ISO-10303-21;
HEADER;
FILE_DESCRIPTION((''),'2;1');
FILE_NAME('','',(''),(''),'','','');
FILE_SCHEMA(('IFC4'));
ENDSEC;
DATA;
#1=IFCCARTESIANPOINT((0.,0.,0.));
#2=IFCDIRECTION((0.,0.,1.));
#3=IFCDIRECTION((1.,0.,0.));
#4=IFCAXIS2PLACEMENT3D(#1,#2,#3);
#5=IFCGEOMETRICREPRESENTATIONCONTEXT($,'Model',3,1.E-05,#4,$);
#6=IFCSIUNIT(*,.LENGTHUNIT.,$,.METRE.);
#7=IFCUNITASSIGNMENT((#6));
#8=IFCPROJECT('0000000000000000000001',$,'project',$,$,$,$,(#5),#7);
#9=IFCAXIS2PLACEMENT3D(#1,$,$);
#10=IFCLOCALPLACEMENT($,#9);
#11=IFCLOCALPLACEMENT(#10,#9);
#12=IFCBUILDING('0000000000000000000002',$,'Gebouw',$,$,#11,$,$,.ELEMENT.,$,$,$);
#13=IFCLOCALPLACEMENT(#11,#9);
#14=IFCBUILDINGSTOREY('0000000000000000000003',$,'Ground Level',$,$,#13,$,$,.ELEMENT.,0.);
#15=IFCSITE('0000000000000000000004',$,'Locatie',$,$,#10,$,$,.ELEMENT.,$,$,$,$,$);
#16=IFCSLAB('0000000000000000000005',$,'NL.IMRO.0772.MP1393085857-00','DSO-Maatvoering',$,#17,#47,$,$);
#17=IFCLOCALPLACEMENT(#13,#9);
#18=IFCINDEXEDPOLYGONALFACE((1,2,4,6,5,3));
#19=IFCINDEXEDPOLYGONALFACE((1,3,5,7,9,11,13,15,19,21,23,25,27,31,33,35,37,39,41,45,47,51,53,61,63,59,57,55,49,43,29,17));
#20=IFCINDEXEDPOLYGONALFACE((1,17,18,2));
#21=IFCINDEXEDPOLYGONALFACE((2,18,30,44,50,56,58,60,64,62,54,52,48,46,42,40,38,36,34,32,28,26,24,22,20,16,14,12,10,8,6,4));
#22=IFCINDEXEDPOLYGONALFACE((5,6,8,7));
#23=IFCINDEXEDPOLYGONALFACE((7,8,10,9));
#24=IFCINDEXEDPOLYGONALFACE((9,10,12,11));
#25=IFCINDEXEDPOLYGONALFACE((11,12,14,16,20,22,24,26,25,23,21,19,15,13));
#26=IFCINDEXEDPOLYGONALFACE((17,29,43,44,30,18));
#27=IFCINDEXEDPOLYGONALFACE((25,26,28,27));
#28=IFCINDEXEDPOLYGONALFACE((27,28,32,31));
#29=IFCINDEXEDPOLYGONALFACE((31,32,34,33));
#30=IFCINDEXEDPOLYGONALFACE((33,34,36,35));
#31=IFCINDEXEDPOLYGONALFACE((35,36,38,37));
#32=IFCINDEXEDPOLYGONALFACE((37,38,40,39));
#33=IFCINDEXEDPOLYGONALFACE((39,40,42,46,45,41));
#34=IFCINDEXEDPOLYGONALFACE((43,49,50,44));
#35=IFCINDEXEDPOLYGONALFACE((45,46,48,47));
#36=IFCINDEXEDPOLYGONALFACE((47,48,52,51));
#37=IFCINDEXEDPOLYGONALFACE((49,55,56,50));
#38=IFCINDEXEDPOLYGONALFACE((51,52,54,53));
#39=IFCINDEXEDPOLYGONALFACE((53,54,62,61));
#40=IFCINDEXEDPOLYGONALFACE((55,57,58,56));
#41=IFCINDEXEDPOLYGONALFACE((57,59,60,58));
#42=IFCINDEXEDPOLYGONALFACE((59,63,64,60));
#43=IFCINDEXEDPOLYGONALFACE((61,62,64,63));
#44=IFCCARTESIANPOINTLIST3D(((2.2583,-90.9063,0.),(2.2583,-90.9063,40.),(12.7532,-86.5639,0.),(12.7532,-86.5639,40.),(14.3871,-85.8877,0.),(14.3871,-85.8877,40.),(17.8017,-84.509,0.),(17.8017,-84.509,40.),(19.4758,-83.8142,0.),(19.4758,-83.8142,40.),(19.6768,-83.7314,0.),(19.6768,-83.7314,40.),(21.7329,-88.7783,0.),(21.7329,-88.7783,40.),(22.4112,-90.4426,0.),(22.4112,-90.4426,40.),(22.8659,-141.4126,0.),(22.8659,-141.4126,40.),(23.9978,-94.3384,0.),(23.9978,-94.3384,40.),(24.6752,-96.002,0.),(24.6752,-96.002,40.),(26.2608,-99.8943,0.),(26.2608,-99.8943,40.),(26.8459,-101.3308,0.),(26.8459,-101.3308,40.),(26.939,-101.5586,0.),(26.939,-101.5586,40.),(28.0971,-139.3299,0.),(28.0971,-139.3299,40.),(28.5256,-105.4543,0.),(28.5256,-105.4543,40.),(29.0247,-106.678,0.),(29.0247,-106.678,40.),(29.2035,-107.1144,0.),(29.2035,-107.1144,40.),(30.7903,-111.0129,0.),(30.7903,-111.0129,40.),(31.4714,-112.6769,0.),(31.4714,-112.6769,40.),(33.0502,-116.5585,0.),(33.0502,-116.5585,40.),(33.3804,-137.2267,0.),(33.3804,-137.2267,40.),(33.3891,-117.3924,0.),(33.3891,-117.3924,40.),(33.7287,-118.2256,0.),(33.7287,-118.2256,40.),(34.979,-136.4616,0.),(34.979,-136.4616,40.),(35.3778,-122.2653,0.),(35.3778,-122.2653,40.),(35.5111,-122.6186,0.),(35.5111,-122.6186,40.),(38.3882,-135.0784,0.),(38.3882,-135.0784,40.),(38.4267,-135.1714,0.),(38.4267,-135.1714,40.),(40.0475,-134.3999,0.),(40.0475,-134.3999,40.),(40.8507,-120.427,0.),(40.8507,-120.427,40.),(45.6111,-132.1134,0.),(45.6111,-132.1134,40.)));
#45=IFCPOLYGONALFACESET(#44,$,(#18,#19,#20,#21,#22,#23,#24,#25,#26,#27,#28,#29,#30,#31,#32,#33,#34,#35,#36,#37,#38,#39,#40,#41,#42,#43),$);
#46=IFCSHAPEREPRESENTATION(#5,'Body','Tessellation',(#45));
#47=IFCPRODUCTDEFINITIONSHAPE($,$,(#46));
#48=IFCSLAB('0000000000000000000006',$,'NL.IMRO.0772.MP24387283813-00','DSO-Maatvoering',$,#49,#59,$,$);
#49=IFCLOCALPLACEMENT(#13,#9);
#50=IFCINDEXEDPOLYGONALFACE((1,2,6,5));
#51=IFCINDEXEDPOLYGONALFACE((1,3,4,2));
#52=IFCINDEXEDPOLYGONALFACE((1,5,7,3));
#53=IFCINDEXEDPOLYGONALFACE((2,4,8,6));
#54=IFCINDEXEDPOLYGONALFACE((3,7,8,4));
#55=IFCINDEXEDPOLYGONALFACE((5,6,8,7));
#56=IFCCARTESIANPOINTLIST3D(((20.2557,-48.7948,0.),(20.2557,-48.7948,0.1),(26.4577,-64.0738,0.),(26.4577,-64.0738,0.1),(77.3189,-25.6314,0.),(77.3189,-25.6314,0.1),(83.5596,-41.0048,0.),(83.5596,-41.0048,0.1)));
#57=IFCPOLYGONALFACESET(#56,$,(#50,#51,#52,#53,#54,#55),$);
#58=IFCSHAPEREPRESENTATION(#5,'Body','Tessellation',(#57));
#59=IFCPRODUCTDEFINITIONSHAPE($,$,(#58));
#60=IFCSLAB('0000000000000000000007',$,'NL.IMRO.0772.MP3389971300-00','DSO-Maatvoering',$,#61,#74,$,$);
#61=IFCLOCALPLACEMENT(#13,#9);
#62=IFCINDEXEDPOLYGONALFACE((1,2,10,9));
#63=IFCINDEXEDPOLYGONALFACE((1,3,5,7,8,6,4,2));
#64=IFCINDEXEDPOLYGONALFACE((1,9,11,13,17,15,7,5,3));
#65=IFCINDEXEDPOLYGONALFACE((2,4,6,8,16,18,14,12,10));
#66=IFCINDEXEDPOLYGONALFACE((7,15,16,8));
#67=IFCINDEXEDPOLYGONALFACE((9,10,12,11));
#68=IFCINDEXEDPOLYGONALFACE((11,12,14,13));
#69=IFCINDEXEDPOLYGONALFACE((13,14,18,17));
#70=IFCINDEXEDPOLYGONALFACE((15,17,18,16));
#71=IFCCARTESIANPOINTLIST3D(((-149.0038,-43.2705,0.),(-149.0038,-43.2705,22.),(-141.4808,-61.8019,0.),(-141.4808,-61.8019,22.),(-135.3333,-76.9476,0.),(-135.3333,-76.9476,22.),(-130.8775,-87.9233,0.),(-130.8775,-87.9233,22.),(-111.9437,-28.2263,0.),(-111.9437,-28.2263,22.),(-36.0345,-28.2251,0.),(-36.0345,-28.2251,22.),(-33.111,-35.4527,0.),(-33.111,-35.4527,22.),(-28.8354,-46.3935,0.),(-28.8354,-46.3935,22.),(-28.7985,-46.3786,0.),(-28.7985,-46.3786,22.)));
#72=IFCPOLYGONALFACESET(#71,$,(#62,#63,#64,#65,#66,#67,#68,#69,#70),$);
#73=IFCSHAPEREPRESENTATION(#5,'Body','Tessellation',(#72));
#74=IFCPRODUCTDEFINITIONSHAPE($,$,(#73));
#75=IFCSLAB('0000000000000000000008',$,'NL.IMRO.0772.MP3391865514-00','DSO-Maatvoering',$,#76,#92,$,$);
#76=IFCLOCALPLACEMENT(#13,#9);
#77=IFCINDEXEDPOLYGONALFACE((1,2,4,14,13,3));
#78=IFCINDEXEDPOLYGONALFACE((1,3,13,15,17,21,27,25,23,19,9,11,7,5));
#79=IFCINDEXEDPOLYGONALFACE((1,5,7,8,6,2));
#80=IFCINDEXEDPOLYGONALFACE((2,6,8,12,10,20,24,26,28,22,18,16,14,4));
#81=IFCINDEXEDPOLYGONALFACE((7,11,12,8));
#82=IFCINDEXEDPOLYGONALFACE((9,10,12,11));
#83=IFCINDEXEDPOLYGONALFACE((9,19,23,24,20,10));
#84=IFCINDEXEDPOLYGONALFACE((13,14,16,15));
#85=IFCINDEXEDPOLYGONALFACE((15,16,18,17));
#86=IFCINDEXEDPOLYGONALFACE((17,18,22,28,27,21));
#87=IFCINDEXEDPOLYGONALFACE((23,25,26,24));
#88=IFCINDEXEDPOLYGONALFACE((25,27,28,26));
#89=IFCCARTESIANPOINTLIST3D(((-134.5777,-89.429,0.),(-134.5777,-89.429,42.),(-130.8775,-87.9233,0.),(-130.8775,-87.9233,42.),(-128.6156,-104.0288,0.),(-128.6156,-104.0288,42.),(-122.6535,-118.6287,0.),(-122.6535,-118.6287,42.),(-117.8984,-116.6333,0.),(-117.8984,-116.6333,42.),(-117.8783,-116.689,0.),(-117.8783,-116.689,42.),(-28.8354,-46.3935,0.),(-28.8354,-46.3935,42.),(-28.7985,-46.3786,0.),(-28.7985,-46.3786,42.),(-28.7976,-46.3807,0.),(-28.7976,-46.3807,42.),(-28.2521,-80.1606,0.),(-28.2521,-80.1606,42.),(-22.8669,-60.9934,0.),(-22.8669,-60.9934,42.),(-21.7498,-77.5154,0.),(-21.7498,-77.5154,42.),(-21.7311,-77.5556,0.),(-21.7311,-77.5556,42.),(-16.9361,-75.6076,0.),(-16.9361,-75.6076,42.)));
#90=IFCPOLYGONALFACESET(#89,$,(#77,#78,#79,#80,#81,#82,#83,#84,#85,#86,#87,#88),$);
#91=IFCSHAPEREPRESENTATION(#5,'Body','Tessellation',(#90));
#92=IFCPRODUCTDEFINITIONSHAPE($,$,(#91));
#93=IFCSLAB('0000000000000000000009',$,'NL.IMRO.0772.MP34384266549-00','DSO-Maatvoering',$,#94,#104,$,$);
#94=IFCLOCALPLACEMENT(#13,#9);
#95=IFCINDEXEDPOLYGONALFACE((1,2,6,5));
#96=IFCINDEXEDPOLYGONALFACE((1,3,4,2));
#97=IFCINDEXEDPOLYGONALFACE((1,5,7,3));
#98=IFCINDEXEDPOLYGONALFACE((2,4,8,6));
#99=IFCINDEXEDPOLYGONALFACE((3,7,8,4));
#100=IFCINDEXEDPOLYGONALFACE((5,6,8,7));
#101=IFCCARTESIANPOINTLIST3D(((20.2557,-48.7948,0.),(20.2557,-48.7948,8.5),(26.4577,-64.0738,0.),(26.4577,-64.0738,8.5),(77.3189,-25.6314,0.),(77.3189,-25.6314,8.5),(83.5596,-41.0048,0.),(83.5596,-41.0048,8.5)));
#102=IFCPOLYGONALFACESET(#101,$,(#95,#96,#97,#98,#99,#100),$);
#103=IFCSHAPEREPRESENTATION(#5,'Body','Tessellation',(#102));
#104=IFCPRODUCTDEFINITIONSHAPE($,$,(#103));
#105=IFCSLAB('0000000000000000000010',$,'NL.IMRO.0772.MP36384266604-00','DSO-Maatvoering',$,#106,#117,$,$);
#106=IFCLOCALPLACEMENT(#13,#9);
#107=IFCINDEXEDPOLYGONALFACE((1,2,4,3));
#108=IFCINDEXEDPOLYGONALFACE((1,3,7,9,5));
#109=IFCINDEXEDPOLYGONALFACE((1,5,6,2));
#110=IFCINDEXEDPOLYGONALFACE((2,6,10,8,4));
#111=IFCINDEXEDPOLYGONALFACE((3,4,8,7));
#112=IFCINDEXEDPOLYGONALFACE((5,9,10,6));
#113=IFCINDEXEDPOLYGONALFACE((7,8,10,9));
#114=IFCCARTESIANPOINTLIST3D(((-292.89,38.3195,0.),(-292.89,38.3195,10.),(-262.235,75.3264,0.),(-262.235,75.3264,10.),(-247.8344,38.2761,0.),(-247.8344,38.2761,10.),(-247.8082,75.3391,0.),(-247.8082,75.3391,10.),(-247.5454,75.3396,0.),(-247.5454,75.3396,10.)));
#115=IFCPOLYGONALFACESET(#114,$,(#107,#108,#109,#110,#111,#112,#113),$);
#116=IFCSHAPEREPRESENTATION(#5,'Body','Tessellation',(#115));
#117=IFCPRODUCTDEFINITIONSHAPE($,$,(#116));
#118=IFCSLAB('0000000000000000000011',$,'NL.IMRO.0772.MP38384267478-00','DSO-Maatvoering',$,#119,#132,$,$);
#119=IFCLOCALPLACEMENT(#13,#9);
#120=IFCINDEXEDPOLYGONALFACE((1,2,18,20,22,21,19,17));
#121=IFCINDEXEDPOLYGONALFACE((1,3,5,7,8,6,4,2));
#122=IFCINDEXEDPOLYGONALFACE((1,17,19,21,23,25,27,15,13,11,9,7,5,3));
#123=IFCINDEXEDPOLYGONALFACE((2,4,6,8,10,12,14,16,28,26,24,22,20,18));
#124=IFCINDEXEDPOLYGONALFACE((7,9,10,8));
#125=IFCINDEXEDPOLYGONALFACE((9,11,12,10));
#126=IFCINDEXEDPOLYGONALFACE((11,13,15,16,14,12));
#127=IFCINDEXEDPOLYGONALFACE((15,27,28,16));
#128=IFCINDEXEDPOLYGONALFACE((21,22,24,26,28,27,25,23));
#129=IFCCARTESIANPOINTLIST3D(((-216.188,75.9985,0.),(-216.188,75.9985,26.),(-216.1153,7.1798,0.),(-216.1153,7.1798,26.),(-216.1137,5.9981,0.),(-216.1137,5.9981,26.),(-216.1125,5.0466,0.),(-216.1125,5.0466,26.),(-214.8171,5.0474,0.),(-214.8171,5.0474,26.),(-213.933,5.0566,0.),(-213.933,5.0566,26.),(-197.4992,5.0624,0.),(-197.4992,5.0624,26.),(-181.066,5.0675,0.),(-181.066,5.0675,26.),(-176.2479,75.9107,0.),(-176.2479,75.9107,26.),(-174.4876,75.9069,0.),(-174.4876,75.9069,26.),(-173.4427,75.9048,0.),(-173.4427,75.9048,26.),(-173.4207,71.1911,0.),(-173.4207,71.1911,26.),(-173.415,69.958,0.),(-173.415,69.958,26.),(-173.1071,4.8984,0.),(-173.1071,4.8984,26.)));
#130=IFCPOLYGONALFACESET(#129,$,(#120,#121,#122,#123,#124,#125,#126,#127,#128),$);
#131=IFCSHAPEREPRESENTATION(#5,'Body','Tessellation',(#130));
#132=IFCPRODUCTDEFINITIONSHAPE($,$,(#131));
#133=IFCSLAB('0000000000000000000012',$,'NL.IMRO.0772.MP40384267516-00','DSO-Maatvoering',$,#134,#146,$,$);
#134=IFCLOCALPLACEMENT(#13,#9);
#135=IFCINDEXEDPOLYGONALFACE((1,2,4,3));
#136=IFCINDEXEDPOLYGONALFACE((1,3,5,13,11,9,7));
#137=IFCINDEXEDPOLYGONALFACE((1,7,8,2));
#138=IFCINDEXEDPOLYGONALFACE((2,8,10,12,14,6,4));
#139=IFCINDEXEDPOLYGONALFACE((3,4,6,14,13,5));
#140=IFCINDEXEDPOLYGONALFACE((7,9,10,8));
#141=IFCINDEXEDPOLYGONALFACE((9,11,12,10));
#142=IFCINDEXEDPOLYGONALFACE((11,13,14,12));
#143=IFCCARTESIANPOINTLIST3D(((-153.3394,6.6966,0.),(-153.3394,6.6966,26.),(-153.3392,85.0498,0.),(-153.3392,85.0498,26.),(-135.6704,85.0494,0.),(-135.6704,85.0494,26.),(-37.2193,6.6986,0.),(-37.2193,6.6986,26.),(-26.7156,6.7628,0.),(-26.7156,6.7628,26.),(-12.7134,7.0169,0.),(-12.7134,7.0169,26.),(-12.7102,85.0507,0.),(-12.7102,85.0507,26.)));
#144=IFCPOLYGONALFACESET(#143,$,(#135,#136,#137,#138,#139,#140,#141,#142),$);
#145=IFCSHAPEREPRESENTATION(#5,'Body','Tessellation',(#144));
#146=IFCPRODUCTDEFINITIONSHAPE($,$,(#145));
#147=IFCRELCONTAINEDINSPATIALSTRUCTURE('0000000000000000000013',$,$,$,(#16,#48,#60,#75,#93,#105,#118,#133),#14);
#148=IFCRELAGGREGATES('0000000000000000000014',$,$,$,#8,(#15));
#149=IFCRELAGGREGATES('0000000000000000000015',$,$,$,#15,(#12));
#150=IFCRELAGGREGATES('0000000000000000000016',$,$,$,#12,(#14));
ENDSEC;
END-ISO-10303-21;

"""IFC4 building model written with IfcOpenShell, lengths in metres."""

from ifc_helpers import new_model, si_unit, origin, origin_with_axes, place, context, project, spatial, polyline, outline, extrude, element, save


model = new_model("IFC4")

# Units and contexts
model_context = context("Model", 3, precision=1e-05, world=origin_with_axes())
ifc_project = project(units=[si_unit("LENGTHUNIT", "METRE")], contexts=[model_context])

# Site, building, storey
site_placement = place(None, origin())
site = spatial("IfcSite", under=ifc_project, at=site_placement, Name="Locatie", CompositionType="ELEMENT")
building_placement = place(site_placement, origin())
building = spatial("IfcBuilding", under=site, at=building_placement, Name="Gebouw", CompositionType="ELEMENT")
storey_placement = place(building_placement, origin())
storey = spatial("IfcBuildingStorey", under=building, at=storey_placement, Name="Ground Level", CompositionType="ELEMENT", Elevation=0.0)

# Slabs
slab_1_placement = place(storey_placement, origin())
element("IfcSlab", 1, at=slab_1_placement, inside=storey, Name="NL.IMRO.0772.MP1393085857-00", Description="DSO-Maatvoering", context=model_context, shape_type="SweptSolid", body=[
    extrude(outline(polyline([(22.8659, -141.4126), (2.2583, -90.9063), (12.7532, -86.5639), (14.3871, -85.8877), (17.8017, -84.509), (19.4758, -83.8142), (19.6768, -83.7314), (21.7329, -88.7783), (22.4112, -90.4426), (23.9978, -94.3384), (24.6752, -96.002), (26.2608, -99.8943), (26.8459, -101.3308), (26.939, -101.5586), (28.5256, -105.4543), (29.0247, -106.678), (29.2035, -107.1144), (30.7903, -111.0129), (31.4714, -112.6769), (33.0502, -116.5585), (33.3891, -117.3924), (33.7287, -118.2256), (35.3778, -122.2653), (35.5111, -122.6186), (40.8507, -120.427), (45.6111, -132.1134), (40.0475, -134.3999), (38.4267, -135.1714), (38.3882, -135.0784), (34.979, -136.4616), (33.3804, -137.2267), (28.0971, -139.3299), (22.8659, -141.4126)])), origin_with_axes(), (0.0, 0.0, 1.0), 40.0),
])
slab_2_placement = place(storey_placement, origin())
element("IfcSlab", 2, at=slab_2_placement, inside=storey, Name="NL.IMRO.0772.MP24387283813-00", Description="DSO-Maatvoering", context=model_context, shape_type="SweptSolid", body=[
    extrude(outline(polyline([(77.3189, -25.6314), (83.5596, -41.0048), (26.4577, -64.0738), (20.2557, -48.7948), (77.3189, -25.6314)])), origin_with_axes(), (0.0, 0.0, 1.0), 0.1),
])
slab_3_placement = place(storey_placement, origin())
element("IfcSlab", 3, at=slab_3_placement, inside=storey, Name="NL.IMRO.0772.MP3389971300-00", Description="DSO-Maatvoering", context=model_context, shape_type="SweptSolid", body=[
    extrude(outline(polyline([(-28.7985, -46.3786), (-28.8354, -46.3935), (-130.8775, -87.9233), (-135.3333, -76.9476), (-141.4808, -61.8019), (-149.0038, -43.2705), (-111.9437, -28.2263), (-36.0345, -28.2251), (-33.111, -35.4527), (-28.7985, -46.3786)])), origin_with_axes(), (0.0, 0.0, 1.0), 22.0),
])
slab_4_placement = place(storey_placement, origin())
element("IfcSlab", 4, at=slab_4_placement, inside=storey, Name="NL.IMRO.0772.MP3391865514-00", Description="DSO-Maatvoering", context=model_context, shape_type="SweptSolid", body=[
    extrude(outline(polyline([(-28.7976, -46.3807), (-22.8669, -60.9934), (-16.9361, -75.6076), (-21.7311, -77.5556), (-21.7498, -77.5154), (-28.2521, -80.1606), (-117.8984, -116.6333), (-117.8783, -116.689), (-122.6535, -118.6287), (-128.6156, -104.0288), (-134.5777, -89.429), (-130.8775, -87.9233), (-28.8354, -46.3935), (-28.7985, -46.3786), (-28.7976, -46.3807)])), origin_with_axes(), (0.0, 0.0, 1.0), 42.0),
])
slab_5_placement = place(storey_placement, origin())
element("IfcSlab", 5, at=slab_5_placement, inside=storey, Name="NL.IMRO.0772.MP34384266549-00", Description="DSO-Maatvoering", context=model_context, shape_type="SweptSolid", body=[
    extrude(outline(polyline([(77.3189, -25.6314), (83.5596, -41.0048), (26.4577, -64.0738), (20.2557, -48.7948), (77.3189, -25.6314)])), origin_with_axes(), (0.0, 0.0, 1.0), 8.5),
])
slab_6_placement = place(storey_placement, origin())
element("IfcSlab", 6, at=slab_6_placement, inside=storey, Name="NL.IMRO.0772.MP36384266604-00", Description="DSO-Maatvoering", context=model_context, shape_type="SweptSolid", body=[
    extrude(outline(polyline([(-247.8082, 75.3391), (-247.5454, 75.3396), (-247.8344, 38.2761), (-292.89, 38.3195), (-262.235, 75.3264), (-247.8082, 75.3391)])), origin_with_axes(), (0.0, 0.0, 1.0), 10.0),
])
slab_7_placement = place(storey_placement, origin())
element("IfcSlab", 7, at=slab_7_placement, inside=storey, Name="NL.IMRO.0772.MP38384267478-00", Description="DSO-Maatvoering", context=model_context, shape_type="SweptSolid", body=[
    extrude(outline(polyline([(-216.1137, 5.9981), (-216.1153, 7.1798), (-216.188, 75.9985), (-176.2479, 75.9107), (-174.4876, 75.9069), (-173.4427, 75.9048), (-173.4207, 71.1911), (-173.415, 69.958), (-173.1071, 4.8984), (-181.066, 5.0675), (-197.4992, 5.0624), (-213.933, 5.0566), (-214.8171, 5.0474), (-216.1125, 5.0466), (-216.1137, 5.9981)])), origin_with_axes(), (0.0, 0.0, 1.0), 26.0),
])
slab_8_placement = place(storey_placement, origin())
element("IfcSlab", 8, at=slab_8_placement, inside=storey, Name="NL.IMRO.0772.MP40384267516-00", Description="DSO-Maatvoering", context=model_context, shape_type="SweptSolid", body=[
    extrude(outline(polyline([(-153.3392, 85.0498), (-135.6704, 85.0494), (-12.7102, 85.0507), (-12.7134, 7.0169), (-26.7156, 6.7628), (-37.2193, 6.6986), (-153.3394, 6.6966), (-153.3392, 85.0498)])), origin_with_axes(), (0.0, 0.0, 1.0), 26.0),
])

save(model, "model.ifc")
